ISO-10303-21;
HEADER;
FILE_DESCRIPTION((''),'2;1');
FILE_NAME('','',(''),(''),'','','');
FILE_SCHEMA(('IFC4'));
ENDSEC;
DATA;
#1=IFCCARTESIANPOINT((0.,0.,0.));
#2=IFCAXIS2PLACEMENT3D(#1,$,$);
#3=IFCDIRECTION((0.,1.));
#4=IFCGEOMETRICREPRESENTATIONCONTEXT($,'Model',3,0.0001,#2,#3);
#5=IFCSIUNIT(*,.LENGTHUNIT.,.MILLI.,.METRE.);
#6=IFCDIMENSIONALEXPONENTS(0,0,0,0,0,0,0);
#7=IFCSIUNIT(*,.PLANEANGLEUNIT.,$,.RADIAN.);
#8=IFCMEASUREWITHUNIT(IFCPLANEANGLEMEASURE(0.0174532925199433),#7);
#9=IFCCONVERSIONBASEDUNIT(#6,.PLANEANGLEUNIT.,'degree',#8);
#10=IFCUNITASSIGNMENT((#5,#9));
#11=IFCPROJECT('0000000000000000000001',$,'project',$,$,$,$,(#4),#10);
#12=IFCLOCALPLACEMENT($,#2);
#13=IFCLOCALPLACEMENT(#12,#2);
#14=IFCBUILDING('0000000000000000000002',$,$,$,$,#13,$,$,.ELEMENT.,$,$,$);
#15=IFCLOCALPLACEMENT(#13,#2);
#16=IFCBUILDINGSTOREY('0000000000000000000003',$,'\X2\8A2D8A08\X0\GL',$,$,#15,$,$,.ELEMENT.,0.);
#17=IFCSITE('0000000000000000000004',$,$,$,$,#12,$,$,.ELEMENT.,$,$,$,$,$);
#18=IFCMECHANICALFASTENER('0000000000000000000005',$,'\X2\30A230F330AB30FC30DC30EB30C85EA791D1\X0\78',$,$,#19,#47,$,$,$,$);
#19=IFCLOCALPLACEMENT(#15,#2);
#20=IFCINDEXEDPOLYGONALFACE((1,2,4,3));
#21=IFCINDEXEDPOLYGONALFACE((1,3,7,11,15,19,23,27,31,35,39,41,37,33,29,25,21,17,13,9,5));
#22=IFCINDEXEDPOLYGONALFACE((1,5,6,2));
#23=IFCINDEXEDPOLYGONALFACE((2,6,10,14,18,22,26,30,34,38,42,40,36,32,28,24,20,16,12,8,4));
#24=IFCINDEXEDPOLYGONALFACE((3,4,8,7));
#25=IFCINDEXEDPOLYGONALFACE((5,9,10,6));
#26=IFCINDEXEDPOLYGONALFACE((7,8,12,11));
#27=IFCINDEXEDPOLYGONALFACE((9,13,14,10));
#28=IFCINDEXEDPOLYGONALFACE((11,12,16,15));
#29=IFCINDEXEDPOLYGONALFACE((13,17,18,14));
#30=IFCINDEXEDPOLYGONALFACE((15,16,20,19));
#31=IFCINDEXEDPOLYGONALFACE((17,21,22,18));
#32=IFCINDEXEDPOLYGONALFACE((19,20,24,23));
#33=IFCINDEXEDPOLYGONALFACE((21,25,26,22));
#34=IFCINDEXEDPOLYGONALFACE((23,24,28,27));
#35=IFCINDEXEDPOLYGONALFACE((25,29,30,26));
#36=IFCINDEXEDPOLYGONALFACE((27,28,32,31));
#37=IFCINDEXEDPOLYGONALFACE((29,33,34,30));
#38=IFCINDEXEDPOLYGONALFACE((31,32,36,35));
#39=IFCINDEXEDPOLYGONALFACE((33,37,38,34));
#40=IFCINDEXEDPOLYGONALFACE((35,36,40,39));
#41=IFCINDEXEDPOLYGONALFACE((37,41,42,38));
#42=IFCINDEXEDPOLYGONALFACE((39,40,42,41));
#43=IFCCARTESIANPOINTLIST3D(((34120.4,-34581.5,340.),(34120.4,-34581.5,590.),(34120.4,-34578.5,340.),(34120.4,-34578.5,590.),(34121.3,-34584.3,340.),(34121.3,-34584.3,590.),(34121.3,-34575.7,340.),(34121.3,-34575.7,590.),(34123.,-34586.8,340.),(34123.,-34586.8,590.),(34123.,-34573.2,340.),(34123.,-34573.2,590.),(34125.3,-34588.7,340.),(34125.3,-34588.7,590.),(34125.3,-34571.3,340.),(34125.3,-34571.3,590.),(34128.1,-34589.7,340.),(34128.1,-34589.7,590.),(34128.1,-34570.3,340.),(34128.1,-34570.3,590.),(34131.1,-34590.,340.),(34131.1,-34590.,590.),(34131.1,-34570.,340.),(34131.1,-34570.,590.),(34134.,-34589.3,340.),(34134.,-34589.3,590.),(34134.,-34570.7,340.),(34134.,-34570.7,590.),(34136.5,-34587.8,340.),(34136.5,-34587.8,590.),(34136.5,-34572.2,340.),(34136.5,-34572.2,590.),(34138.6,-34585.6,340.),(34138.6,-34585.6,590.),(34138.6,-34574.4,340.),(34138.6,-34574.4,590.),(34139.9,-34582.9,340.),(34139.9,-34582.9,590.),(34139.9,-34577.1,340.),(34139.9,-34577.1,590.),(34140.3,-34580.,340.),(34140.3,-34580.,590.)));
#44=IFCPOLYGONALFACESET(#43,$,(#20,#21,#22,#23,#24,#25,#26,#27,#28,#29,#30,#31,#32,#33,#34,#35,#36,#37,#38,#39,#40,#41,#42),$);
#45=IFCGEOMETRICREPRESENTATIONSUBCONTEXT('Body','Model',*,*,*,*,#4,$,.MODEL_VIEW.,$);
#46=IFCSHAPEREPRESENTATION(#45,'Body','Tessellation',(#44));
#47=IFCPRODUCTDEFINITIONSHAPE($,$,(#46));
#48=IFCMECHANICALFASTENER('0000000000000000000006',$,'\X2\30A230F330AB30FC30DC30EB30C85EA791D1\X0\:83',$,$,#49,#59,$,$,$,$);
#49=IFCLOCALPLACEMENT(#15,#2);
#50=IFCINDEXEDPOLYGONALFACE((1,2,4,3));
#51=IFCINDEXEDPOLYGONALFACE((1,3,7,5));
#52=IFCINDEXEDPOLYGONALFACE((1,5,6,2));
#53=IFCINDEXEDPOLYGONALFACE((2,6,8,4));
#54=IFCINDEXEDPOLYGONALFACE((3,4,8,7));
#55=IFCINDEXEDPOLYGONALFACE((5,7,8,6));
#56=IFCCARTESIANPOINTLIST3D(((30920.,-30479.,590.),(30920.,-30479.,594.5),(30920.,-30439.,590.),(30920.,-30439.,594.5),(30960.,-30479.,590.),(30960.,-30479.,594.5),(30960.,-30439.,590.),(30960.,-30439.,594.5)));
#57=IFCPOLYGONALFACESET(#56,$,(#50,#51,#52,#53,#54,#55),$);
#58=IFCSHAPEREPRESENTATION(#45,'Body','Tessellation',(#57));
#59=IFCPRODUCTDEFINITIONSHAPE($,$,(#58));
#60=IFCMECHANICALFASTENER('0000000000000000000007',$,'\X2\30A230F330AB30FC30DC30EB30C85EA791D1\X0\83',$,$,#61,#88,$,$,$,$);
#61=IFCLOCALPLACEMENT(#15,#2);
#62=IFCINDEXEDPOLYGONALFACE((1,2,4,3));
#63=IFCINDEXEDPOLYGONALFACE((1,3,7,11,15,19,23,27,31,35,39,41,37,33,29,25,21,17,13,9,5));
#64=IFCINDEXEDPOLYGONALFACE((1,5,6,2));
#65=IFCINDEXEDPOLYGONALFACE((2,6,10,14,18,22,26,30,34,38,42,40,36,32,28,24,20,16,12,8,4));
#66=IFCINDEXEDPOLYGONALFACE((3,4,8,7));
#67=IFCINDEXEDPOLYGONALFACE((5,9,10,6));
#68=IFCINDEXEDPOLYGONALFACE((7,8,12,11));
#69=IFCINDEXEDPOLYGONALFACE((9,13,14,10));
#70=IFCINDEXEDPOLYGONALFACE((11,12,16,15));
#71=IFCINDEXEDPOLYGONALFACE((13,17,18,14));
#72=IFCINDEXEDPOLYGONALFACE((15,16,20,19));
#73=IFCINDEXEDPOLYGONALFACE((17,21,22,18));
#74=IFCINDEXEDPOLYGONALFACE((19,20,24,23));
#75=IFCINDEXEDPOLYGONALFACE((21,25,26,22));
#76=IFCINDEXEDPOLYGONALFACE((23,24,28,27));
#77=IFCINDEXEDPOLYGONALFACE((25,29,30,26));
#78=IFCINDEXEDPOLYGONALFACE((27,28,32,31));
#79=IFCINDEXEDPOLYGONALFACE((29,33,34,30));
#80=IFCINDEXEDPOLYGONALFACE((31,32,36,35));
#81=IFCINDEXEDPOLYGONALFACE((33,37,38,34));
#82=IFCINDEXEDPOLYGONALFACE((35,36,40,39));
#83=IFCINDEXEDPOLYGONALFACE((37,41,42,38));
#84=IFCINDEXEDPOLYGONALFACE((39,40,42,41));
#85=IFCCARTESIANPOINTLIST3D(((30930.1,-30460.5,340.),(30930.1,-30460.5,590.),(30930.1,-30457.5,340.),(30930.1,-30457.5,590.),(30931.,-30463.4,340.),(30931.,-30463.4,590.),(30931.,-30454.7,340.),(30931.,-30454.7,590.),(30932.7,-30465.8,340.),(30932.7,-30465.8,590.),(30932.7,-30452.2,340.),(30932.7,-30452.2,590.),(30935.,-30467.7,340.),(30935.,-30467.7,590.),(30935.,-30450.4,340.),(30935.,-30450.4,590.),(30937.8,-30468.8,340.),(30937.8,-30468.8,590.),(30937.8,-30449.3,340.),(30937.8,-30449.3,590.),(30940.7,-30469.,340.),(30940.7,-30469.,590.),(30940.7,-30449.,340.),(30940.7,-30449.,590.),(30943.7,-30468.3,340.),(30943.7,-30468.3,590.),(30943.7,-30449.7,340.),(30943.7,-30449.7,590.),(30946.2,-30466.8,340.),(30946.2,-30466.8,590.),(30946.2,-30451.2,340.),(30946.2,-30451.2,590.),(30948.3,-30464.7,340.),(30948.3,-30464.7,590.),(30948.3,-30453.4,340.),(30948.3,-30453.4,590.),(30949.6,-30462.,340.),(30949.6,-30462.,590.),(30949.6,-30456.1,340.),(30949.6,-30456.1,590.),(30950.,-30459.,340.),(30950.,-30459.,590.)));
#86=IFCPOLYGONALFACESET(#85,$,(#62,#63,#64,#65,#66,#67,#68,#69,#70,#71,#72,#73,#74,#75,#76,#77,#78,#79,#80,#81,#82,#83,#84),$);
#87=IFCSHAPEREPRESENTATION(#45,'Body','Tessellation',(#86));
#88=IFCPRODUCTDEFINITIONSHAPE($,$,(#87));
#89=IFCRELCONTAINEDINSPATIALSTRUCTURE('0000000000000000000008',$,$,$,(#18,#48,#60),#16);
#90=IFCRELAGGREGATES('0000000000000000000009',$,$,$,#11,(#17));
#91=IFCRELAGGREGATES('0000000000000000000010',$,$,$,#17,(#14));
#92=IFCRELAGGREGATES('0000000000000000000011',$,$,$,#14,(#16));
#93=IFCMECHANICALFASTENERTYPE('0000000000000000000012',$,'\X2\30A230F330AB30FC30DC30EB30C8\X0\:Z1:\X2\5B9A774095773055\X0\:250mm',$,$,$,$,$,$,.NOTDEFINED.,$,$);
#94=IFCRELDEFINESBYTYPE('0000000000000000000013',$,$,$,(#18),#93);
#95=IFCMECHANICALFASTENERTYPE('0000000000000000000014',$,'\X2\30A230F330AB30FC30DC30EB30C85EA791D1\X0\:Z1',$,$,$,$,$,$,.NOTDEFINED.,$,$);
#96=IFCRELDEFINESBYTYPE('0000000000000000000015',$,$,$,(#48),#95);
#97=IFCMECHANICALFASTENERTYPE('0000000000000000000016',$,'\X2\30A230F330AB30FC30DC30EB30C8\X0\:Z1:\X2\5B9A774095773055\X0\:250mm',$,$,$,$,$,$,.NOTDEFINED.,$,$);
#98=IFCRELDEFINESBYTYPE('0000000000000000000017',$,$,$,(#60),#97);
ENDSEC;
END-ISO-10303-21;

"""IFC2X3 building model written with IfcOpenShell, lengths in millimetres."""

from ifc_helpers import new_model, entity, si_unit, converted_unit, direction, frame, origin, origin_with_axes, origin_2d, place, context, subcontext, project, spatial, rectangle, circle, extrude, type_object, element, save


model = new_model("IFC2X3")

# Units and contexts
model_context = context("Model", 3, precision=0.0001, world=origin(), true_north=direction((0.0, 1.0)))
body_context = subcontext(model_context, "Body", "Model", "MODEL_VIEW")
ifc_project = project(units=[si_unit("LENGTHUNIT", "METRE", prefix="MILLI"), converted_unit("PLANEANGLEUNIT", "degree", entity("IfcPlaneAngleMeasure", 0.0174532925199433), si_unit("PLANEANGLEUNIT", "RADIAN"), dimensions=[0, 0, 0, 0, 0, 0, 0])], contexts=[model_context])

# Site, building, storey
site_placement = place(None, origin())
site = spatial("IfcSite", under=ifc_project, at=site_placement, CompositionType="ELEMENT")
building_placement = place(site_placement, origin())
building = spatial("IfcBuilding", under=site, at=building_placement, CompositionType="ELEMENT")
storey_placement = place(building_placement, origin())
storey = spatial("IfcBuildingStorey", under=building, at=storey_placement, Name="設計GL", CompositionType="ELEMENT", Elevation=0.0)

# Mechanical fasteners
mechanical_fastener_type_1 = type_object("IfcMechanicalFastenerType", Name="アンカーボルト:Z1:定着長さ:250mm")
mechanical_fastener_1_placement = place(storey_placement, frame((34130.3, -34580.0, 340.0)))
element("IfcMechanicalFastener", 1, at=mechanical_fastener_1_placement, inside=storey, type_object=mechanical_fastener_type_1, Name="アンカーボルト座金78", context=body_context, shape_type="SweptSolid", body=[
    extrude(circle(Radius=10.0, at=origin_2d()), origin_with_axes(), (0.0, 0.0, 1.0), 250.0),
])
mechanical_fastener_type_2 = type_object("IfcMechanicalFastenerType", Name="アンカーボルト座金:Z1")
mechanical_fastener_2_placement = place(storey_placement, frame((30940.0, -30459.0, 590.0)))
element("IfcMechanicalFastener", 2, at=mechanical_fastener_2_placement, inside=storey, type_object=mechanical_fastener_type_2, Name="アンカーボルト座金:83", context=body_context, shape_type="SweptSolid", body=[
    extrude(rectangle(XDim=40.0, YDim=40.0, at=origin_2d()), origin_with_axes(), (0.0, 0.0, 1.0), 4.5),
])
mechanical_fastener_type_3 = type_object("IfcMechanicalFastenerType", Name="アンカーボルト:Z1:定着長さ:250mm")
mechanical_fastener_3_placement = place(storey_placement, frame((30940.0, -30459.0, 340.0)))
element("IfcMechanicalFastener", 3, at=mechanical_fastener_3_placement, inside=storey, type_object=mechanical_fastener_type_3, Name="アンカーボルト座金83", context=body_context, shape_type="SweptSolid", body=[
    extrude(circle(Radius=10.0, at=origin_2d()), origin_with_axes(), (0.0, 0.0, 1.0), 250.0),
])

save(model, "model.ifc")
